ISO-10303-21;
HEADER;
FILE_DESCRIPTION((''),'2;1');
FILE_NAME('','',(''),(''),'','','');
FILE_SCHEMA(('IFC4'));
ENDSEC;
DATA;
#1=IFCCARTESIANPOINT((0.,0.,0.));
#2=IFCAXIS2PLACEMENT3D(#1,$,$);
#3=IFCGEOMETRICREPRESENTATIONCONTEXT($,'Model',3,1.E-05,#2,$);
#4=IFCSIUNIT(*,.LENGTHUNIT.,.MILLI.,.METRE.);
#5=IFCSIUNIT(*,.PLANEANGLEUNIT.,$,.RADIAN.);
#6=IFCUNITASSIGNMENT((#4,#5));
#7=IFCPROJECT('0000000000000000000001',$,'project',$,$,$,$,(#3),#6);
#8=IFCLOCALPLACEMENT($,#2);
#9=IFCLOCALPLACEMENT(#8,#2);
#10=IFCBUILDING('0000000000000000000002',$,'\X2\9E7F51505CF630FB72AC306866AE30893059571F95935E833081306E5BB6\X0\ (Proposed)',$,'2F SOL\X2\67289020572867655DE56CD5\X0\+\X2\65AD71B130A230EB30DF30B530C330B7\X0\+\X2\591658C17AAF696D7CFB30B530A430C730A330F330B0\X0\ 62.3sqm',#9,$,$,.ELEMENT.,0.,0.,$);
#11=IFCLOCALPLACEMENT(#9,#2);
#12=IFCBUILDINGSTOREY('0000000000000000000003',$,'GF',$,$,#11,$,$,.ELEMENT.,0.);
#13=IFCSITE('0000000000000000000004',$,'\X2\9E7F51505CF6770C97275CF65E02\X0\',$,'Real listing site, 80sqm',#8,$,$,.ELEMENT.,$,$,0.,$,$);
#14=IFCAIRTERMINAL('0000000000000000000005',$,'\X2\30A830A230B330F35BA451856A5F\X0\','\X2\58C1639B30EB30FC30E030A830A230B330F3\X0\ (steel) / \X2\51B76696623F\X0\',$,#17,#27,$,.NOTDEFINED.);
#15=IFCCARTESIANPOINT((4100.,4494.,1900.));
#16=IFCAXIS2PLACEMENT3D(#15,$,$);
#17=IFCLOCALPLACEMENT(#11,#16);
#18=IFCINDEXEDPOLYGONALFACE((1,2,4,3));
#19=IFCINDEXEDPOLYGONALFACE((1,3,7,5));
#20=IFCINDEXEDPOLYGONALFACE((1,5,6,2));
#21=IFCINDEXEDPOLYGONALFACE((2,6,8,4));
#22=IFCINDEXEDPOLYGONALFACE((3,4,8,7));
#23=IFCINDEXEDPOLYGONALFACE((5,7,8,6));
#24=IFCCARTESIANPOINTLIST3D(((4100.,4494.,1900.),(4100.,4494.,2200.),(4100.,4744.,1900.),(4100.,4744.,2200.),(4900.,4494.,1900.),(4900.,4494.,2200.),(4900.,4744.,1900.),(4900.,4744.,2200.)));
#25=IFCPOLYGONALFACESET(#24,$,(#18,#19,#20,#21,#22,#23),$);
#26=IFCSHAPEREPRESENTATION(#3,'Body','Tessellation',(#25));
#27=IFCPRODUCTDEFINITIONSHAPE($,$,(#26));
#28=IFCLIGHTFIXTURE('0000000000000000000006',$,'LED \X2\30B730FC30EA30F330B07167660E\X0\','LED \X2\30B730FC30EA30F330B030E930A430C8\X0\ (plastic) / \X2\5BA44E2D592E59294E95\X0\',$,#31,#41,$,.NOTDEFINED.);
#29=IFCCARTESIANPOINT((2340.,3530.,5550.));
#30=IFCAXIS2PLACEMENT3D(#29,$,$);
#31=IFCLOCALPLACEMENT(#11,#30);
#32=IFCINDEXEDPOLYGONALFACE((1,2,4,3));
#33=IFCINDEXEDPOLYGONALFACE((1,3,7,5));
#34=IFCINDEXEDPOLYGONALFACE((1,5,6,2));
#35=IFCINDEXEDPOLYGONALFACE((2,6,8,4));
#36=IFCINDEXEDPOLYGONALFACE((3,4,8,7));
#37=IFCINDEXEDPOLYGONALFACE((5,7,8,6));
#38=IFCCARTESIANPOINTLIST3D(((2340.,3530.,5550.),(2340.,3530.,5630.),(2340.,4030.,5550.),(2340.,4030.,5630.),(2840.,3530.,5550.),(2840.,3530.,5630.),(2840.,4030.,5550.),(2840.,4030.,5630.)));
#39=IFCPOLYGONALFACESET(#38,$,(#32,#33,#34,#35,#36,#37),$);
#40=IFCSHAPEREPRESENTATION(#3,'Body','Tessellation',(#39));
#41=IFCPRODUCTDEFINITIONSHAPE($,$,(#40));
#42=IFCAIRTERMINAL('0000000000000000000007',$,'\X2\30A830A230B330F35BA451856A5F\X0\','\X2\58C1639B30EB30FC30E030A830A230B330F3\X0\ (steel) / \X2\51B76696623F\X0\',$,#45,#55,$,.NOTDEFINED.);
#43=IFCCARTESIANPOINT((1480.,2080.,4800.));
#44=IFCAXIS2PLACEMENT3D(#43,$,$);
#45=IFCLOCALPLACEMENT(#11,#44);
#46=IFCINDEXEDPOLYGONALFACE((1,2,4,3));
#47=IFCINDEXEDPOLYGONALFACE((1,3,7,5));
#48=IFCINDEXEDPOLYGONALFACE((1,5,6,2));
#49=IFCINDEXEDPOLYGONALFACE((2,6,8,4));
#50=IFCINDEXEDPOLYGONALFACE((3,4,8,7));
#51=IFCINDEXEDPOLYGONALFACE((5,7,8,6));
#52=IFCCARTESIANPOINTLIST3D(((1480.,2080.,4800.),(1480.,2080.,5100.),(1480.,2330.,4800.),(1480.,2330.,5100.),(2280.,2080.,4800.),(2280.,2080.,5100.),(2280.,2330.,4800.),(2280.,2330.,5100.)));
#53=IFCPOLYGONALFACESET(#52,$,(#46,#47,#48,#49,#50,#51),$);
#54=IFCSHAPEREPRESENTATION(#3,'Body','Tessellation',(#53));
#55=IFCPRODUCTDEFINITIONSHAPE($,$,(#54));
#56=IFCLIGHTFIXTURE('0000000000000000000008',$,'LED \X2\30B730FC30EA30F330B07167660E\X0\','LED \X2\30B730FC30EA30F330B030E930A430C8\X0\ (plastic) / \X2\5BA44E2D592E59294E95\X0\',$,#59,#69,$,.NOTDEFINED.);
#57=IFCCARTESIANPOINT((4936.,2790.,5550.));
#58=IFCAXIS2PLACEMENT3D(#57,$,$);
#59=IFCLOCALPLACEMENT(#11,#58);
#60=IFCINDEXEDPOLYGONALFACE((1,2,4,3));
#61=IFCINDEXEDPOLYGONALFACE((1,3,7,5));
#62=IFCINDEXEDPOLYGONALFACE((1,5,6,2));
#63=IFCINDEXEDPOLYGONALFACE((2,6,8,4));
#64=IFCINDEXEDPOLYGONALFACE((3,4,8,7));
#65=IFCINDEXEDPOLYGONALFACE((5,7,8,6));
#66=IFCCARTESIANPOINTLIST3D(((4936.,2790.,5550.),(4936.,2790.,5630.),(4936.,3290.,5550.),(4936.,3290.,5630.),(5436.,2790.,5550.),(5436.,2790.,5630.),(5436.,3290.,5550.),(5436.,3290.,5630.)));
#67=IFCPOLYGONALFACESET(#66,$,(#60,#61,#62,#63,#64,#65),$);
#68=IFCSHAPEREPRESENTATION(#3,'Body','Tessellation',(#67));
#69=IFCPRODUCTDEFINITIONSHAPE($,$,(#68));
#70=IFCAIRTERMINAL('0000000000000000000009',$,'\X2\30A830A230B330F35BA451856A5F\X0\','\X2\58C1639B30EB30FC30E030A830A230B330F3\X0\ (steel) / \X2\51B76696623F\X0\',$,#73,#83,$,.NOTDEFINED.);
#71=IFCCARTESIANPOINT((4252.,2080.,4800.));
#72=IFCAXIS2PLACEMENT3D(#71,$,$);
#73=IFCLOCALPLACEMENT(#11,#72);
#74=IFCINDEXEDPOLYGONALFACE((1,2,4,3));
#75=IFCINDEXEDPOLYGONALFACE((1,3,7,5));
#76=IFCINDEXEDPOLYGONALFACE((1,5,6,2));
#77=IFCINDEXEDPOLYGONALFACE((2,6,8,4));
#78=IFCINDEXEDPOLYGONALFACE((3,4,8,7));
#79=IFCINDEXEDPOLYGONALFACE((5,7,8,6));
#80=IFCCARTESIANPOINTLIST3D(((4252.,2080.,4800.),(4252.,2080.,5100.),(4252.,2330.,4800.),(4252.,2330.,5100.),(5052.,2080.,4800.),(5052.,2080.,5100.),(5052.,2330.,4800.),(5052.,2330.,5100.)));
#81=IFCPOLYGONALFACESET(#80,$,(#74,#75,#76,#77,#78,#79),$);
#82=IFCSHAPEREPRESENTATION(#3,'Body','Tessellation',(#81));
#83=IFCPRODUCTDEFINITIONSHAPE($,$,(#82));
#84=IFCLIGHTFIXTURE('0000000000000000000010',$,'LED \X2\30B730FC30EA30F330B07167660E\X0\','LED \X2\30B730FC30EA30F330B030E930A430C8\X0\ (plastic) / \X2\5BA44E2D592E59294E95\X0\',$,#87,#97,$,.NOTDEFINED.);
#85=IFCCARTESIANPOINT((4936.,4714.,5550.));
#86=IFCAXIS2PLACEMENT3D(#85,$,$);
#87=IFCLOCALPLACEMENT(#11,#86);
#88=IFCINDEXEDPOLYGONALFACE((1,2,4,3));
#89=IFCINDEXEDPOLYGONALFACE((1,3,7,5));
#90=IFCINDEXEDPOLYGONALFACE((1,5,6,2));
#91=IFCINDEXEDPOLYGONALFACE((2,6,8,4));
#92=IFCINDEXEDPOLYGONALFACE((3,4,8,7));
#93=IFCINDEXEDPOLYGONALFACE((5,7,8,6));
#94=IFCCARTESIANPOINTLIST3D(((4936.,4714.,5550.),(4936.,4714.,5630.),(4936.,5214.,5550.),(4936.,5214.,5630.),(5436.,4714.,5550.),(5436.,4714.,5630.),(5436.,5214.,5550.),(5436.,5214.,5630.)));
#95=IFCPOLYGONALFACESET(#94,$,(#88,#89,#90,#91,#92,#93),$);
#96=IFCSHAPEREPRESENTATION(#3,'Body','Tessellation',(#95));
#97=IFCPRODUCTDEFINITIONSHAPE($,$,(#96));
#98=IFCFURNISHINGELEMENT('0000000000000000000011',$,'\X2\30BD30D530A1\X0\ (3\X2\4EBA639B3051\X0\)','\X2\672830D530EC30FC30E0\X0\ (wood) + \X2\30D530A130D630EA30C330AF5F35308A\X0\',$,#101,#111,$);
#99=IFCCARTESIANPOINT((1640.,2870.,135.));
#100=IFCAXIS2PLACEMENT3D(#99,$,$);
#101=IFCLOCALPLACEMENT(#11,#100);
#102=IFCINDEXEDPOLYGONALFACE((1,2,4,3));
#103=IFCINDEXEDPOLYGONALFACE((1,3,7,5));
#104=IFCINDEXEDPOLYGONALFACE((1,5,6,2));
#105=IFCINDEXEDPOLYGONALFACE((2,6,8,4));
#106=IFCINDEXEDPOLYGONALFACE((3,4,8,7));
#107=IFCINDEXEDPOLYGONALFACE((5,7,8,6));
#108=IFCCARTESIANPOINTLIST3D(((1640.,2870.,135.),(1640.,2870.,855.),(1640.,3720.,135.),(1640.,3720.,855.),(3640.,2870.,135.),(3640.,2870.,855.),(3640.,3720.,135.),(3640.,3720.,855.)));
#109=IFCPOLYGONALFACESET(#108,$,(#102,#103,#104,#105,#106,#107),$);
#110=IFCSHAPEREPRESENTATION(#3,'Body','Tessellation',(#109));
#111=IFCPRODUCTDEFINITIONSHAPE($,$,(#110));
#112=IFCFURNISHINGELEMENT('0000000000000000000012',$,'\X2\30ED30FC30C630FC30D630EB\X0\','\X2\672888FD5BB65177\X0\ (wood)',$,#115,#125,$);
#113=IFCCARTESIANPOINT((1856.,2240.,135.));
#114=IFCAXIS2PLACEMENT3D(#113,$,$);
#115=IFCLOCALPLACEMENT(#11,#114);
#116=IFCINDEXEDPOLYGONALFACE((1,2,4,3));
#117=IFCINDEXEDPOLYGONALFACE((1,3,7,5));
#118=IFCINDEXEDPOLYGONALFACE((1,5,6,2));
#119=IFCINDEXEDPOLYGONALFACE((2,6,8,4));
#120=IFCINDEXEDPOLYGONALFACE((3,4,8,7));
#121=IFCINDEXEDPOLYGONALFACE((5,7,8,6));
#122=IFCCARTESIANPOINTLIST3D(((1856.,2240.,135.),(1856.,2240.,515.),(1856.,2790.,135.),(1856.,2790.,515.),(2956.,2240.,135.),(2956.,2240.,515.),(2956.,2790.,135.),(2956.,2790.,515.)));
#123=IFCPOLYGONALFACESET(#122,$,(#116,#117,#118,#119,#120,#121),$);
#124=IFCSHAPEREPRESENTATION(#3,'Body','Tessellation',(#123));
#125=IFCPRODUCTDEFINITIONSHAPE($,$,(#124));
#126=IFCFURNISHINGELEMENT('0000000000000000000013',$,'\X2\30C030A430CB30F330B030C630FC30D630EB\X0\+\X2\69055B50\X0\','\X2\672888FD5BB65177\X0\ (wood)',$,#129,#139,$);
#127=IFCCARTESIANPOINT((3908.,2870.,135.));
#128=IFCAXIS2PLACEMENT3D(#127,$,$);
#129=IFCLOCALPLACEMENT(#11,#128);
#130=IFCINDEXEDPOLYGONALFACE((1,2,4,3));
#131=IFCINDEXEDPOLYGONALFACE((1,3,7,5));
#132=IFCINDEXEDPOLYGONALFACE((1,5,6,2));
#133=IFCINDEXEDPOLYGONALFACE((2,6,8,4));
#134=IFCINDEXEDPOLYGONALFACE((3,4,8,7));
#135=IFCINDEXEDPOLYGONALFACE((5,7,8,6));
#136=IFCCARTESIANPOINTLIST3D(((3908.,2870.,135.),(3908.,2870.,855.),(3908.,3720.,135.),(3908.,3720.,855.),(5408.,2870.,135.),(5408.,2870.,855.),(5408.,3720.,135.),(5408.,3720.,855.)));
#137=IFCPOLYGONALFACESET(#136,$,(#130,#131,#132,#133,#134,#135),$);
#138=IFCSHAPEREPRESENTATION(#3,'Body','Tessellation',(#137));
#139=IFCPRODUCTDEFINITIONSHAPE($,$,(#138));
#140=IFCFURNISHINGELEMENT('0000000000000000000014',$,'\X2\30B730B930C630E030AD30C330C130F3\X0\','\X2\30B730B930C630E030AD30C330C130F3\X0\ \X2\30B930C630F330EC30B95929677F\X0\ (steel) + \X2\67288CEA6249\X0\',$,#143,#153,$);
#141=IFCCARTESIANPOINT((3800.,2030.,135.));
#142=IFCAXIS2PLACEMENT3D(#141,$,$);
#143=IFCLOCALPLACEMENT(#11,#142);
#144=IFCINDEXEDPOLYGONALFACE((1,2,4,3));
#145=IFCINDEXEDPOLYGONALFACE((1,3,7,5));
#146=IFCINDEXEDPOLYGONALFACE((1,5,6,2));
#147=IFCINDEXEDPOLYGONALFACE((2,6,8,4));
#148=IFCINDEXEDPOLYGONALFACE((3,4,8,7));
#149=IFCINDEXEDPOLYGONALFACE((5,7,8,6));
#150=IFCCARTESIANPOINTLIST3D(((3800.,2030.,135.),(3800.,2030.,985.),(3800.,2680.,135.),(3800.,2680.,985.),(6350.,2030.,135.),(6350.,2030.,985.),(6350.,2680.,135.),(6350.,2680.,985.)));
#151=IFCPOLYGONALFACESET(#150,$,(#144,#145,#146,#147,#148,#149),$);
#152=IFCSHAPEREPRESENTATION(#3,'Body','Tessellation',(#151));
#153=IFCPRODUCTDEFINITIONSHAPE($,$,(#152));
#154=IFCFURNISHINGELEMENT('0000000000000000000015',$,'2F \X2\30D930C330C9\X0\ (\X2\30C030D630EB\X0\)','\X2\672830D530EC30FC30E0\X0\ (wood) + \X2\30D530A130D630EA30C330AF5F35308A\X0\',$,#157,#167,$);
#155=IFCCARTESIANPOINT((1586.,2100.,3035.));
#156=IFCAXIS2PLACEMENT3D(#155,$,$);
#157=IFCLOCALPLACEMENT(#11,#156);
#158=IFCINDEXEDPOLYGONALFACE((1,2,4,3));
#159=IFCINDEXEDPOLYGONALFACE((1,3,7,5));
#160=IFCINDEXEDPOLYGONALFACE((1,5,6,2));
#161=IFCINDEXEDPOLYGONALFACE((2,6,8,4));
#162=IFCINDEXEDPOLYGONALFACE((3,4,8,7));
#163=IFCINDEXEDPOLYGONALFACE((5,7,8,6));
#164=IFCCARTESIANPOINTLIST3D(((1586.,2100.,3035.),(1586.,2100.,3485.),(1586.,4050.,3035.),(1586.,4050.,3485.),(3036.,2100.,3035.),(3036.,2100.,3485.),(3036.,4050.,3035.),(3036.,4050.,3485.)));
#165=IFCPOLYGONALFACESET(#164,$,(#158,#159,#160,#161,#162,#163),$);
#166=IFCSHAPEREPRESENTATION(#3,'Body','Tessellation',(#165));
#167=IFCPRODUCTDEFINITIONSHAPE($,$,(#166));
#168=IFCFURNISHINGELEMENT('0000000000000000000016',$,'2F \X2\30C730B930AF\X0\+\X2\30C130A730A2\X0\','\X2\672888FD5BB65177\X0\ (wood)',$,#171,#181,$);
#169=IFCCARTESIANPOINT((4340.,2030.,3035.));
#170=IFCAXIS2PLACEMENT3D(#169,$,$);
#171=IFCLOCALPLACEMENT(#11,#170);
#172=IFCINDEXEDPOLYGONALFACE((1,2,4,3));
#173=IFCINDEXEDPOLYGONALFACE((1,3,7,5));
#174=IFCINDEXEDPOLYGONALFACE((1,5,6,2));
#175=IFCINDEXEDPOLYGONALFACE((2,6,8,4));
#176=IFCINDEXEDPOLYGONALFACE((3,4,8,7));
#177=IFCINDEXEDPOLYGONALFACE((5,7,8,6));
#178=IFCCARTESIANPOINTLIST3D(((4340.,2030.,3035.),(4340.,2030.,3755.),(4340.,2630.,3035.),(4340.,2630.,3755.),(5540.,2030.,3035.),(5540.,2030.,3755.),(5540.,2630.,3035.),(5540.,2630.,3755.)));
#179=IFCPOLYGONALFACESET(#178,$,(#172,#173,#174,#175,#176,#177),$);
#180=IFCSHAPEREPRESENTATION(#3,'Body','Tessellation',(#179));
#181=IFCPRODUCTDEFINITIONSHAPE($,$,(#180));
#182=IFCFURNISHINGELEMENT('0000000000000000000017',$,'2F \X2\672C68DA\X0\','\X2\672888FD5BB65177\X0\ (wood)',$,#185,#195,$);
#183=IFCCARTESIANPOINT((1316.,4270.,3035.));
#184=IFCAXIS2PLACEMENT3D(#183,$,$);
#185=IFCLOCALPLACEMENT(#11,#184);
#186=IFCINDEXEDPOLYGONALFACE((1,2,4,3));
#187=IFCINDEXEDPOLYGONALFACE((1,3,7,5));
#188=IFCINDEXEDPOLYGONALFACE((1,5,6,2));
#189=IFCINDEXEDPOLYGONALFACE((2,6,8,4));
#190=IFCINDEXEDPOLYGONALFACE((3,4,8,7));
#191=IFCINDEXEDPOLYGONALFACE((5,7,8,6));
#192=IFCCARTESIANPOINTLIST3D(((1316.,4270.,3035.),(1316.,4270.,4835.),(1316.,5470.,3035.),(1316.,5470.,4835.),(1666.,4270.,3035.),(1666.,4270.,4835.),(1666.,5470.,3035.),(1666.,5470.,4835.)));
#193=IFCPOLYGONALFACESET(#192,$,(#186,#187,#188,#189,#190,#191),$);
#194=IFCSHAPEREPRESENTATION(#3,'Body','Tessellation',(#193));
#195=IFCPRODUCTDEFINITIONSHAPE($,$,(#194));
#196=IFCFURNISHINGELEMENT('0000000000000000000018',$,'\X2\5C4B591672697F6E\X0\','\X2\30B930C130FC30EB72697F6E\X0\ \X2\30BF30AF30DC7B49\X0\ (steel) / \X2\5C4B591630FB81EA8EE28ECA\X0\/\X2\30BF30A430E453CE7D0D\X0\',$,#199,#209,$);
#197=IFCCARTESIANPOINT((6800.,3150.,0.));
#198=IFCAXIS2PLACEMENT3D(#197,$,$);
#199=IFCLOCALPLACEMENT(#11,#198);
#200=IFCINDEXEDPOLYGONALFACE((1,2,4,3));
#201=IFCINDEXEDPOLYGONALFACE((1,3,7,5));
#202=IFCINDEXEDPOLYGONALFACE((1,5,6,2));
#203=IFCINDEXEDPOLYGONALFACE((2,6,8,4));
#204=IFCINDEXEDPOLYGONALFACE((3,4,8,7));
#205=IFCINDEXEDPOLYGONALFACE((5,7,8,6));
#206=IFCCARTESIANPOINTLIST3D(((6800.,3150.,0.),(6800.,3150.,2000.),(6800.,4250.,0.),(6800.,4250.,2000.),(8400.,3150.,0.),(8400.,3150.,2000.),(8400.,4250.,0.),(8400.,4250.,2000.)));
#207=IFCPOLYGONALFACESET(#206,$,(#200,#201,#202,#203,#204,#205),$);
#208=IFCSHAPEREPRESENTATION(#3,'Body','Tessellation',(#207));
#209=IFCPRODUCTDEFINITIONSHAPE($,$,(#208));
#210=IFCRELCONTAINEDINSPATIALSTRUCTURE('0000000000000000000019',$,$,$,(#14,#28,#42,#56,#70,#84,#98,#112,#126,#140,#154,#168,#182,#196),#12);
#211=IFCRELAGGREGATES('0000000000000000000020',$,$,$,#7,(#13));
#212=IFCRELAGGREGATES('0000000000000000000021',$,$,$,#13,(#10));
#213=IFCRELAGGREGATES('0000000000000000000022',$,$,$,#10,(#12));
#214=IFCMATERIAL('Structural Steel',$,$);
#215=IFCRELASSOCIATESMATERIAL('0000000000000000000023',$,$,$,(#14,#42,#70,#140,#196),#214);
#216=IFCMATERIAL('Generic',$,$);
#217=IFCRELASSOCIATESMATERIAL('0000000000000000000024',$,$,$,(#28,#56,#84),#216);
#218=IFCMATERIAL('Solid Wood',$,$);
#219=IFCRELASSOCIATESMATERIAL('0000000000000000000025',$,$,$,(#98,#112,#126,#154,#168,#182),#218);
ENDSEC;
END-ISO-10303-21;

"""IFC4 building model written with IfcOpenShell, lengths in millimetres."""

from ifc_helpers import new_model, si_unit, frame, frame_2d, origin, place, context, project, spatial, rectangle, extrude, material, element, save


model = new_model("IFC4")

# Units and contexts
model_context = context("Model", 3, precision=1e-05, world=origin())
ifc_project = project(units=[si_unit("LENGTHUNIT", "METRE", prefix="MILLI"), si_unit("PLANEANGLEUNIT", "RADIAN")], contexts=[model_context])

# Site, building, storey
site_placement = place(None, origin())
site = spatial("IfcSite", under=ifc_project, at=site_placement, Name="鹿児島県霧島市", ObjectType="Real listing site, 80sqm", CompositionType="ELEMENT", RefElevation=0.0)
building_placement = place(site_placement, origin())
building = spatial("IfcBuilding", under=site, at=building_placement, Name="鹿児島・犬と暮らす土間広めの家 (Proposed)", ObjectType="2F SOL木造在来工法+断熱アルミサッシ+外壁窯業系サイディング 62.3sqm", CompositionType="ELEMENT", ElevationOfRefHeight=0.0, ElevationOfTerrain=0.0)
storey_placement = place(building_placement, origin())
storey = spatial("IfcBuildingStorey", under=building, at=storey_placement, Name="GF", CompositionType="ELEMENT", Elevation=0.0)

# Shared definitions
ifc_material_1 = material(Name="Solid Wood")

# Shared definitions
ifc_material_2 = material(Name="Structural Steel")

# Shared definitions
ifc_material_3 = material(Name="Generic")

# Air terminal
air_terminal_1_placement = place(storey_placement, frame((4100.0, 4494.0, 1900.0)))
element("IfcAirTerminal", 1, at=air_terminal_1_placement, inside=storey, material=ifc_material_2, Name="エアコン室内機", Description="壁掛ルームエアコン (steel) / 冷暖房", PredefinedType="NOTDEFINED", context=model_context, shape_type="SweptSolid", body=[
    extrude(rectangle(XDim=800.0, YDim=250.0, at=frame_2d((400.0, 125.0))), frame((4100.0, 4494.0, 1900.0)), (0.0, 0.0, 1.0), 300.0),
])

# Light fixture
light_fixture_1_placement = place(storey_placement, frame((2340.0, 3530.0, 5550.0)))
element("IfcLightFixture", 2, at=light_fixture_1_placement, inside=storey, material=ifc_material_3, Name="LED シーリング照明", Description="LED シーリングライト (plastic) / 室中央天井", PredefinedType="NOTDEFINED", context=model_context, shape_type="SweptSolid", body=[
    extrude(rectangle(XDim=500.0, YDim=500.0, at=frame_2d((250.0, 250.0))), frame((2340.0, 3530.0, 5550.0)), (0.0, 0.0, 1.0), 80.0),
])

# Air terminal
air_terminal_2_placement = place(storey_placement, frame((1480.0, 2080.0, 4800.0)))
element("IfcAirTerminal", 3, at=air_terminal_2_placement, inside=storey, material=ifc_material_2, Name="エアコン室内機", Description="壁掛ルームエアコン (steel) / 冷暖房", PredefinedType="NOTDEFINED", context=model_context, shape_type="SweptSolid", body=[
    extrude(rectangle(XDim=800.0, YDim=250.0, at=frame_2d((400.0, 125.0))), frame((1480.0, 2080.0, 4800.0)), (0.0, 0.0, 1.0), 300.0),
])

# Light fixture
light_fixture_2_placement = place(storey_placement, frame((4936.0, 2790.0, 5550.0)))
element("IfcLightFixture", 4, at=light_fixture_2_placement, inside=storey, material=ifc_material_3, Name="LED シーリング照明", Description="LED シーリングライト (plastic) / 室中央天井", PredefinedType="NOTDEFINED", context=model_context, shape_type="SweptSolid", body=[
    extrude(rectangle(XDim=500.0, YDim=500.0, at=frame_2d((250.0, 250.0))), frame((4936.0, 2790.0, 5550.0)), (0.0, 0.0, 1.0), 80.0),
])

# Air terminal
air_terminal_3_placement = place(storey_placement, frame((4252.0, 2080.0, 4800.0)))
element("IfcAirTerminal", 5, at=air_terminal_3_placement, inside=storey, material=ifc_material_2, Name="エアコン室内機", Description="壁掛ルームエアコン (steel) / 冷暖房", PredefinedType="NOTDEFINED", context=model_context, shape_type="SweptSolid", body=[
    extrude(rectangle(XDim=800.0, YDim=250.0, at=frame_2d((400.0, 125.0))), frame((4252.0, 2080.0, 4800.0)), (0.0, 0.0, 1.0), 300.0),
])

# Light fixture
light_fixture_3_placement = place(storey_placement, frame((4936.0, 4714.0, 5550.0)))
element("IfcLightFixture", 6, at=light_fixture_3_placement, inside=storey, material=ifc_material_3, Name="LED シーリング照明", Description="LED シーリングライト (plastic) / 室中央天井", PredefinedType="NOTDEFINED", context=model_context, shape_type="SweptSolid", body=[
    extrude(rectangle(XDim=500.0, YDim=500.0, at=frame_2d((250.0, 250.0))), frame((4936.0, 4714.0, 5550.0)), (0.0, 0.0, 1.0), 80.0),
])

# Furnishing elements
furnishing_1_placement = place(storey_placement, frame((1640.0, 2870.0, 135.0)))
element("IfcFurnishingElement", 7, at=furnishing_1_placement, inside=storey, material=ifc_material_1, Name="ソファ (3人掛け)", Description="木フレーム (wood) + ファブリック張り", context=model_context, shape_type="SweptSolid", body=[
    extrude(rectangle(XDim=2000.0, YDim=850.0, at=frame_2d((1000.0, 425.0))), frame((1640.0, 2870.0, 135.0)), (0.0, 0.0, 1.0), 720.0),
])
furnishing_2_placement = place(storey_placement, frame((1856.0, 2240.0, 135.0)))
element("IfcFurnishingElement", 8, at=furnishing_2_placement, inside=storey, material=ifc_material_1, Name="ローテーブル", Description="木製家具 (wood)", context=model_context, shape_type="SweptSolid", body=[
    extrude(rectangle(XDim=1100.0, YDim=550.0, at=frame_2d((550.0, 275.0))), frame((1856.0, 2240.0, 135.0)), (0.0, 0.0, 1.0), 380.0),
])
furnishing_3_placement = place(storey_placement, frame((3908.0, 2870.0, 135.0)))
element("IfcFurnishingElement", 9, at=furnishing_3_placement, inside=storey, material=ifc_material_1, Name="ダイニングテーブル+椅子", Description="木製家具 (wood)", context=model_context, shape_type="SweptSolid", body=[
    extrude(rectangle(XDim=1500.0, YDim=850.0, at=frame_2d((750.0, 425.0))), frame((3908.0, 2870.0, 135.0)), (0.0, 0.0, 1.0), 720.0),
])
furnishing_4_placement = place(storey_placement, frame((3800.0, 2030.0, 135.0)))
element("IfcFurnishingElement", 10, at=furnishing_4_placement, inside=storey, material=ifc_material_2, Name="システムキッチン", Description="システムキッチン ステンレス天板 (steel) + 木質扉", context=model_context, shape_type="SweptSolid", body=[
    extrude(rectangle(XDim=2550.0, YDim=650.0, at=frame_2d((1275.0, 325.0))), frame((3800.0, 2030.0, 135.0)), (0.0, 0.0, 1.0), 850.0),
])
furnishing_5_placement = place(storey_placement, frame((1586.0, 2100.0, 3035.0)))
element("IfcFurnishingElement", 11, at=furnishing_5_placement, inside=storey, material=ifc_material_1, Name="2F ベッド (ダブル)", Description="木フレーム (wood) + ファブリック張り", context=model_context, shape_type="SweptSolid", body=[
    extrude(rectangle(XDim=1450.0, YDim=1950.0, at=frame_2d((725.0, 975.0))), frame((1586.0, 2100.0, 3035.0)), (0.0, 0.0, 1.0), 450.0),
])
furnishing_6_placement = place(storey_placement, frame((4340.0, 2030.0, 3035.0)))
element("IfcFurnishingElement", 12, at=furnishing_6_placement, inside=storey, material=ifc_material_1, Name="2F デスク+チェア", Description="木製家具 (wood)", context=model_context, shape_type="SweptSolid", body=[
    extrude(rectangle(XDim=1200.0, YDim=600.0, at=frame_2d((600.0, 300.0))), frame((4340.0, 2030.0, 3035.0)), (0.0, 0.0, 1.0), 720.0),
])
furnishing_7_placement = place(storey_placement, frame((1316.0, 4270.0, 3035.0)))
element("IfcFurnishingElement", 13, at=furnishing_7_placement, inside=storey, material=ifc_material_1, Name="2F 本棚", Description="木製家具 (wood)", context=model_context, shape_type="SweptSolid", body=[
    extrude(rectangle(XDim=350.0, YDim=1200.0, at=frame_2d((175.0, 600.0))), frame((1316.0, 4270.0, 3035.0)), (0.0, 0.0, 1.0), 1800.0),
])
furnishing_8_placement = place(storey_placement, frame((6800.0, 3150.0, 0.0)))
element("IfcFurnishingElement", 14, at=furnishing_8_placement, inside=storey, material=ifc_material_2, Name="屋外物置", Description="スチール物置 タクボ等 (steel) / 屋外・自転車/タイヤ収納", context=model_context, shape_type="SweptSolid", body=[
    extrude(rectangle(XDim=1600.0, YDim=1100.0, at=frame_2d((800.0, 550.0))), frame((6800.0, 3150.0, 0.0)), (0.0, 0.0, 1.0), 2000.0),
])

save(model, "model.ifc")
